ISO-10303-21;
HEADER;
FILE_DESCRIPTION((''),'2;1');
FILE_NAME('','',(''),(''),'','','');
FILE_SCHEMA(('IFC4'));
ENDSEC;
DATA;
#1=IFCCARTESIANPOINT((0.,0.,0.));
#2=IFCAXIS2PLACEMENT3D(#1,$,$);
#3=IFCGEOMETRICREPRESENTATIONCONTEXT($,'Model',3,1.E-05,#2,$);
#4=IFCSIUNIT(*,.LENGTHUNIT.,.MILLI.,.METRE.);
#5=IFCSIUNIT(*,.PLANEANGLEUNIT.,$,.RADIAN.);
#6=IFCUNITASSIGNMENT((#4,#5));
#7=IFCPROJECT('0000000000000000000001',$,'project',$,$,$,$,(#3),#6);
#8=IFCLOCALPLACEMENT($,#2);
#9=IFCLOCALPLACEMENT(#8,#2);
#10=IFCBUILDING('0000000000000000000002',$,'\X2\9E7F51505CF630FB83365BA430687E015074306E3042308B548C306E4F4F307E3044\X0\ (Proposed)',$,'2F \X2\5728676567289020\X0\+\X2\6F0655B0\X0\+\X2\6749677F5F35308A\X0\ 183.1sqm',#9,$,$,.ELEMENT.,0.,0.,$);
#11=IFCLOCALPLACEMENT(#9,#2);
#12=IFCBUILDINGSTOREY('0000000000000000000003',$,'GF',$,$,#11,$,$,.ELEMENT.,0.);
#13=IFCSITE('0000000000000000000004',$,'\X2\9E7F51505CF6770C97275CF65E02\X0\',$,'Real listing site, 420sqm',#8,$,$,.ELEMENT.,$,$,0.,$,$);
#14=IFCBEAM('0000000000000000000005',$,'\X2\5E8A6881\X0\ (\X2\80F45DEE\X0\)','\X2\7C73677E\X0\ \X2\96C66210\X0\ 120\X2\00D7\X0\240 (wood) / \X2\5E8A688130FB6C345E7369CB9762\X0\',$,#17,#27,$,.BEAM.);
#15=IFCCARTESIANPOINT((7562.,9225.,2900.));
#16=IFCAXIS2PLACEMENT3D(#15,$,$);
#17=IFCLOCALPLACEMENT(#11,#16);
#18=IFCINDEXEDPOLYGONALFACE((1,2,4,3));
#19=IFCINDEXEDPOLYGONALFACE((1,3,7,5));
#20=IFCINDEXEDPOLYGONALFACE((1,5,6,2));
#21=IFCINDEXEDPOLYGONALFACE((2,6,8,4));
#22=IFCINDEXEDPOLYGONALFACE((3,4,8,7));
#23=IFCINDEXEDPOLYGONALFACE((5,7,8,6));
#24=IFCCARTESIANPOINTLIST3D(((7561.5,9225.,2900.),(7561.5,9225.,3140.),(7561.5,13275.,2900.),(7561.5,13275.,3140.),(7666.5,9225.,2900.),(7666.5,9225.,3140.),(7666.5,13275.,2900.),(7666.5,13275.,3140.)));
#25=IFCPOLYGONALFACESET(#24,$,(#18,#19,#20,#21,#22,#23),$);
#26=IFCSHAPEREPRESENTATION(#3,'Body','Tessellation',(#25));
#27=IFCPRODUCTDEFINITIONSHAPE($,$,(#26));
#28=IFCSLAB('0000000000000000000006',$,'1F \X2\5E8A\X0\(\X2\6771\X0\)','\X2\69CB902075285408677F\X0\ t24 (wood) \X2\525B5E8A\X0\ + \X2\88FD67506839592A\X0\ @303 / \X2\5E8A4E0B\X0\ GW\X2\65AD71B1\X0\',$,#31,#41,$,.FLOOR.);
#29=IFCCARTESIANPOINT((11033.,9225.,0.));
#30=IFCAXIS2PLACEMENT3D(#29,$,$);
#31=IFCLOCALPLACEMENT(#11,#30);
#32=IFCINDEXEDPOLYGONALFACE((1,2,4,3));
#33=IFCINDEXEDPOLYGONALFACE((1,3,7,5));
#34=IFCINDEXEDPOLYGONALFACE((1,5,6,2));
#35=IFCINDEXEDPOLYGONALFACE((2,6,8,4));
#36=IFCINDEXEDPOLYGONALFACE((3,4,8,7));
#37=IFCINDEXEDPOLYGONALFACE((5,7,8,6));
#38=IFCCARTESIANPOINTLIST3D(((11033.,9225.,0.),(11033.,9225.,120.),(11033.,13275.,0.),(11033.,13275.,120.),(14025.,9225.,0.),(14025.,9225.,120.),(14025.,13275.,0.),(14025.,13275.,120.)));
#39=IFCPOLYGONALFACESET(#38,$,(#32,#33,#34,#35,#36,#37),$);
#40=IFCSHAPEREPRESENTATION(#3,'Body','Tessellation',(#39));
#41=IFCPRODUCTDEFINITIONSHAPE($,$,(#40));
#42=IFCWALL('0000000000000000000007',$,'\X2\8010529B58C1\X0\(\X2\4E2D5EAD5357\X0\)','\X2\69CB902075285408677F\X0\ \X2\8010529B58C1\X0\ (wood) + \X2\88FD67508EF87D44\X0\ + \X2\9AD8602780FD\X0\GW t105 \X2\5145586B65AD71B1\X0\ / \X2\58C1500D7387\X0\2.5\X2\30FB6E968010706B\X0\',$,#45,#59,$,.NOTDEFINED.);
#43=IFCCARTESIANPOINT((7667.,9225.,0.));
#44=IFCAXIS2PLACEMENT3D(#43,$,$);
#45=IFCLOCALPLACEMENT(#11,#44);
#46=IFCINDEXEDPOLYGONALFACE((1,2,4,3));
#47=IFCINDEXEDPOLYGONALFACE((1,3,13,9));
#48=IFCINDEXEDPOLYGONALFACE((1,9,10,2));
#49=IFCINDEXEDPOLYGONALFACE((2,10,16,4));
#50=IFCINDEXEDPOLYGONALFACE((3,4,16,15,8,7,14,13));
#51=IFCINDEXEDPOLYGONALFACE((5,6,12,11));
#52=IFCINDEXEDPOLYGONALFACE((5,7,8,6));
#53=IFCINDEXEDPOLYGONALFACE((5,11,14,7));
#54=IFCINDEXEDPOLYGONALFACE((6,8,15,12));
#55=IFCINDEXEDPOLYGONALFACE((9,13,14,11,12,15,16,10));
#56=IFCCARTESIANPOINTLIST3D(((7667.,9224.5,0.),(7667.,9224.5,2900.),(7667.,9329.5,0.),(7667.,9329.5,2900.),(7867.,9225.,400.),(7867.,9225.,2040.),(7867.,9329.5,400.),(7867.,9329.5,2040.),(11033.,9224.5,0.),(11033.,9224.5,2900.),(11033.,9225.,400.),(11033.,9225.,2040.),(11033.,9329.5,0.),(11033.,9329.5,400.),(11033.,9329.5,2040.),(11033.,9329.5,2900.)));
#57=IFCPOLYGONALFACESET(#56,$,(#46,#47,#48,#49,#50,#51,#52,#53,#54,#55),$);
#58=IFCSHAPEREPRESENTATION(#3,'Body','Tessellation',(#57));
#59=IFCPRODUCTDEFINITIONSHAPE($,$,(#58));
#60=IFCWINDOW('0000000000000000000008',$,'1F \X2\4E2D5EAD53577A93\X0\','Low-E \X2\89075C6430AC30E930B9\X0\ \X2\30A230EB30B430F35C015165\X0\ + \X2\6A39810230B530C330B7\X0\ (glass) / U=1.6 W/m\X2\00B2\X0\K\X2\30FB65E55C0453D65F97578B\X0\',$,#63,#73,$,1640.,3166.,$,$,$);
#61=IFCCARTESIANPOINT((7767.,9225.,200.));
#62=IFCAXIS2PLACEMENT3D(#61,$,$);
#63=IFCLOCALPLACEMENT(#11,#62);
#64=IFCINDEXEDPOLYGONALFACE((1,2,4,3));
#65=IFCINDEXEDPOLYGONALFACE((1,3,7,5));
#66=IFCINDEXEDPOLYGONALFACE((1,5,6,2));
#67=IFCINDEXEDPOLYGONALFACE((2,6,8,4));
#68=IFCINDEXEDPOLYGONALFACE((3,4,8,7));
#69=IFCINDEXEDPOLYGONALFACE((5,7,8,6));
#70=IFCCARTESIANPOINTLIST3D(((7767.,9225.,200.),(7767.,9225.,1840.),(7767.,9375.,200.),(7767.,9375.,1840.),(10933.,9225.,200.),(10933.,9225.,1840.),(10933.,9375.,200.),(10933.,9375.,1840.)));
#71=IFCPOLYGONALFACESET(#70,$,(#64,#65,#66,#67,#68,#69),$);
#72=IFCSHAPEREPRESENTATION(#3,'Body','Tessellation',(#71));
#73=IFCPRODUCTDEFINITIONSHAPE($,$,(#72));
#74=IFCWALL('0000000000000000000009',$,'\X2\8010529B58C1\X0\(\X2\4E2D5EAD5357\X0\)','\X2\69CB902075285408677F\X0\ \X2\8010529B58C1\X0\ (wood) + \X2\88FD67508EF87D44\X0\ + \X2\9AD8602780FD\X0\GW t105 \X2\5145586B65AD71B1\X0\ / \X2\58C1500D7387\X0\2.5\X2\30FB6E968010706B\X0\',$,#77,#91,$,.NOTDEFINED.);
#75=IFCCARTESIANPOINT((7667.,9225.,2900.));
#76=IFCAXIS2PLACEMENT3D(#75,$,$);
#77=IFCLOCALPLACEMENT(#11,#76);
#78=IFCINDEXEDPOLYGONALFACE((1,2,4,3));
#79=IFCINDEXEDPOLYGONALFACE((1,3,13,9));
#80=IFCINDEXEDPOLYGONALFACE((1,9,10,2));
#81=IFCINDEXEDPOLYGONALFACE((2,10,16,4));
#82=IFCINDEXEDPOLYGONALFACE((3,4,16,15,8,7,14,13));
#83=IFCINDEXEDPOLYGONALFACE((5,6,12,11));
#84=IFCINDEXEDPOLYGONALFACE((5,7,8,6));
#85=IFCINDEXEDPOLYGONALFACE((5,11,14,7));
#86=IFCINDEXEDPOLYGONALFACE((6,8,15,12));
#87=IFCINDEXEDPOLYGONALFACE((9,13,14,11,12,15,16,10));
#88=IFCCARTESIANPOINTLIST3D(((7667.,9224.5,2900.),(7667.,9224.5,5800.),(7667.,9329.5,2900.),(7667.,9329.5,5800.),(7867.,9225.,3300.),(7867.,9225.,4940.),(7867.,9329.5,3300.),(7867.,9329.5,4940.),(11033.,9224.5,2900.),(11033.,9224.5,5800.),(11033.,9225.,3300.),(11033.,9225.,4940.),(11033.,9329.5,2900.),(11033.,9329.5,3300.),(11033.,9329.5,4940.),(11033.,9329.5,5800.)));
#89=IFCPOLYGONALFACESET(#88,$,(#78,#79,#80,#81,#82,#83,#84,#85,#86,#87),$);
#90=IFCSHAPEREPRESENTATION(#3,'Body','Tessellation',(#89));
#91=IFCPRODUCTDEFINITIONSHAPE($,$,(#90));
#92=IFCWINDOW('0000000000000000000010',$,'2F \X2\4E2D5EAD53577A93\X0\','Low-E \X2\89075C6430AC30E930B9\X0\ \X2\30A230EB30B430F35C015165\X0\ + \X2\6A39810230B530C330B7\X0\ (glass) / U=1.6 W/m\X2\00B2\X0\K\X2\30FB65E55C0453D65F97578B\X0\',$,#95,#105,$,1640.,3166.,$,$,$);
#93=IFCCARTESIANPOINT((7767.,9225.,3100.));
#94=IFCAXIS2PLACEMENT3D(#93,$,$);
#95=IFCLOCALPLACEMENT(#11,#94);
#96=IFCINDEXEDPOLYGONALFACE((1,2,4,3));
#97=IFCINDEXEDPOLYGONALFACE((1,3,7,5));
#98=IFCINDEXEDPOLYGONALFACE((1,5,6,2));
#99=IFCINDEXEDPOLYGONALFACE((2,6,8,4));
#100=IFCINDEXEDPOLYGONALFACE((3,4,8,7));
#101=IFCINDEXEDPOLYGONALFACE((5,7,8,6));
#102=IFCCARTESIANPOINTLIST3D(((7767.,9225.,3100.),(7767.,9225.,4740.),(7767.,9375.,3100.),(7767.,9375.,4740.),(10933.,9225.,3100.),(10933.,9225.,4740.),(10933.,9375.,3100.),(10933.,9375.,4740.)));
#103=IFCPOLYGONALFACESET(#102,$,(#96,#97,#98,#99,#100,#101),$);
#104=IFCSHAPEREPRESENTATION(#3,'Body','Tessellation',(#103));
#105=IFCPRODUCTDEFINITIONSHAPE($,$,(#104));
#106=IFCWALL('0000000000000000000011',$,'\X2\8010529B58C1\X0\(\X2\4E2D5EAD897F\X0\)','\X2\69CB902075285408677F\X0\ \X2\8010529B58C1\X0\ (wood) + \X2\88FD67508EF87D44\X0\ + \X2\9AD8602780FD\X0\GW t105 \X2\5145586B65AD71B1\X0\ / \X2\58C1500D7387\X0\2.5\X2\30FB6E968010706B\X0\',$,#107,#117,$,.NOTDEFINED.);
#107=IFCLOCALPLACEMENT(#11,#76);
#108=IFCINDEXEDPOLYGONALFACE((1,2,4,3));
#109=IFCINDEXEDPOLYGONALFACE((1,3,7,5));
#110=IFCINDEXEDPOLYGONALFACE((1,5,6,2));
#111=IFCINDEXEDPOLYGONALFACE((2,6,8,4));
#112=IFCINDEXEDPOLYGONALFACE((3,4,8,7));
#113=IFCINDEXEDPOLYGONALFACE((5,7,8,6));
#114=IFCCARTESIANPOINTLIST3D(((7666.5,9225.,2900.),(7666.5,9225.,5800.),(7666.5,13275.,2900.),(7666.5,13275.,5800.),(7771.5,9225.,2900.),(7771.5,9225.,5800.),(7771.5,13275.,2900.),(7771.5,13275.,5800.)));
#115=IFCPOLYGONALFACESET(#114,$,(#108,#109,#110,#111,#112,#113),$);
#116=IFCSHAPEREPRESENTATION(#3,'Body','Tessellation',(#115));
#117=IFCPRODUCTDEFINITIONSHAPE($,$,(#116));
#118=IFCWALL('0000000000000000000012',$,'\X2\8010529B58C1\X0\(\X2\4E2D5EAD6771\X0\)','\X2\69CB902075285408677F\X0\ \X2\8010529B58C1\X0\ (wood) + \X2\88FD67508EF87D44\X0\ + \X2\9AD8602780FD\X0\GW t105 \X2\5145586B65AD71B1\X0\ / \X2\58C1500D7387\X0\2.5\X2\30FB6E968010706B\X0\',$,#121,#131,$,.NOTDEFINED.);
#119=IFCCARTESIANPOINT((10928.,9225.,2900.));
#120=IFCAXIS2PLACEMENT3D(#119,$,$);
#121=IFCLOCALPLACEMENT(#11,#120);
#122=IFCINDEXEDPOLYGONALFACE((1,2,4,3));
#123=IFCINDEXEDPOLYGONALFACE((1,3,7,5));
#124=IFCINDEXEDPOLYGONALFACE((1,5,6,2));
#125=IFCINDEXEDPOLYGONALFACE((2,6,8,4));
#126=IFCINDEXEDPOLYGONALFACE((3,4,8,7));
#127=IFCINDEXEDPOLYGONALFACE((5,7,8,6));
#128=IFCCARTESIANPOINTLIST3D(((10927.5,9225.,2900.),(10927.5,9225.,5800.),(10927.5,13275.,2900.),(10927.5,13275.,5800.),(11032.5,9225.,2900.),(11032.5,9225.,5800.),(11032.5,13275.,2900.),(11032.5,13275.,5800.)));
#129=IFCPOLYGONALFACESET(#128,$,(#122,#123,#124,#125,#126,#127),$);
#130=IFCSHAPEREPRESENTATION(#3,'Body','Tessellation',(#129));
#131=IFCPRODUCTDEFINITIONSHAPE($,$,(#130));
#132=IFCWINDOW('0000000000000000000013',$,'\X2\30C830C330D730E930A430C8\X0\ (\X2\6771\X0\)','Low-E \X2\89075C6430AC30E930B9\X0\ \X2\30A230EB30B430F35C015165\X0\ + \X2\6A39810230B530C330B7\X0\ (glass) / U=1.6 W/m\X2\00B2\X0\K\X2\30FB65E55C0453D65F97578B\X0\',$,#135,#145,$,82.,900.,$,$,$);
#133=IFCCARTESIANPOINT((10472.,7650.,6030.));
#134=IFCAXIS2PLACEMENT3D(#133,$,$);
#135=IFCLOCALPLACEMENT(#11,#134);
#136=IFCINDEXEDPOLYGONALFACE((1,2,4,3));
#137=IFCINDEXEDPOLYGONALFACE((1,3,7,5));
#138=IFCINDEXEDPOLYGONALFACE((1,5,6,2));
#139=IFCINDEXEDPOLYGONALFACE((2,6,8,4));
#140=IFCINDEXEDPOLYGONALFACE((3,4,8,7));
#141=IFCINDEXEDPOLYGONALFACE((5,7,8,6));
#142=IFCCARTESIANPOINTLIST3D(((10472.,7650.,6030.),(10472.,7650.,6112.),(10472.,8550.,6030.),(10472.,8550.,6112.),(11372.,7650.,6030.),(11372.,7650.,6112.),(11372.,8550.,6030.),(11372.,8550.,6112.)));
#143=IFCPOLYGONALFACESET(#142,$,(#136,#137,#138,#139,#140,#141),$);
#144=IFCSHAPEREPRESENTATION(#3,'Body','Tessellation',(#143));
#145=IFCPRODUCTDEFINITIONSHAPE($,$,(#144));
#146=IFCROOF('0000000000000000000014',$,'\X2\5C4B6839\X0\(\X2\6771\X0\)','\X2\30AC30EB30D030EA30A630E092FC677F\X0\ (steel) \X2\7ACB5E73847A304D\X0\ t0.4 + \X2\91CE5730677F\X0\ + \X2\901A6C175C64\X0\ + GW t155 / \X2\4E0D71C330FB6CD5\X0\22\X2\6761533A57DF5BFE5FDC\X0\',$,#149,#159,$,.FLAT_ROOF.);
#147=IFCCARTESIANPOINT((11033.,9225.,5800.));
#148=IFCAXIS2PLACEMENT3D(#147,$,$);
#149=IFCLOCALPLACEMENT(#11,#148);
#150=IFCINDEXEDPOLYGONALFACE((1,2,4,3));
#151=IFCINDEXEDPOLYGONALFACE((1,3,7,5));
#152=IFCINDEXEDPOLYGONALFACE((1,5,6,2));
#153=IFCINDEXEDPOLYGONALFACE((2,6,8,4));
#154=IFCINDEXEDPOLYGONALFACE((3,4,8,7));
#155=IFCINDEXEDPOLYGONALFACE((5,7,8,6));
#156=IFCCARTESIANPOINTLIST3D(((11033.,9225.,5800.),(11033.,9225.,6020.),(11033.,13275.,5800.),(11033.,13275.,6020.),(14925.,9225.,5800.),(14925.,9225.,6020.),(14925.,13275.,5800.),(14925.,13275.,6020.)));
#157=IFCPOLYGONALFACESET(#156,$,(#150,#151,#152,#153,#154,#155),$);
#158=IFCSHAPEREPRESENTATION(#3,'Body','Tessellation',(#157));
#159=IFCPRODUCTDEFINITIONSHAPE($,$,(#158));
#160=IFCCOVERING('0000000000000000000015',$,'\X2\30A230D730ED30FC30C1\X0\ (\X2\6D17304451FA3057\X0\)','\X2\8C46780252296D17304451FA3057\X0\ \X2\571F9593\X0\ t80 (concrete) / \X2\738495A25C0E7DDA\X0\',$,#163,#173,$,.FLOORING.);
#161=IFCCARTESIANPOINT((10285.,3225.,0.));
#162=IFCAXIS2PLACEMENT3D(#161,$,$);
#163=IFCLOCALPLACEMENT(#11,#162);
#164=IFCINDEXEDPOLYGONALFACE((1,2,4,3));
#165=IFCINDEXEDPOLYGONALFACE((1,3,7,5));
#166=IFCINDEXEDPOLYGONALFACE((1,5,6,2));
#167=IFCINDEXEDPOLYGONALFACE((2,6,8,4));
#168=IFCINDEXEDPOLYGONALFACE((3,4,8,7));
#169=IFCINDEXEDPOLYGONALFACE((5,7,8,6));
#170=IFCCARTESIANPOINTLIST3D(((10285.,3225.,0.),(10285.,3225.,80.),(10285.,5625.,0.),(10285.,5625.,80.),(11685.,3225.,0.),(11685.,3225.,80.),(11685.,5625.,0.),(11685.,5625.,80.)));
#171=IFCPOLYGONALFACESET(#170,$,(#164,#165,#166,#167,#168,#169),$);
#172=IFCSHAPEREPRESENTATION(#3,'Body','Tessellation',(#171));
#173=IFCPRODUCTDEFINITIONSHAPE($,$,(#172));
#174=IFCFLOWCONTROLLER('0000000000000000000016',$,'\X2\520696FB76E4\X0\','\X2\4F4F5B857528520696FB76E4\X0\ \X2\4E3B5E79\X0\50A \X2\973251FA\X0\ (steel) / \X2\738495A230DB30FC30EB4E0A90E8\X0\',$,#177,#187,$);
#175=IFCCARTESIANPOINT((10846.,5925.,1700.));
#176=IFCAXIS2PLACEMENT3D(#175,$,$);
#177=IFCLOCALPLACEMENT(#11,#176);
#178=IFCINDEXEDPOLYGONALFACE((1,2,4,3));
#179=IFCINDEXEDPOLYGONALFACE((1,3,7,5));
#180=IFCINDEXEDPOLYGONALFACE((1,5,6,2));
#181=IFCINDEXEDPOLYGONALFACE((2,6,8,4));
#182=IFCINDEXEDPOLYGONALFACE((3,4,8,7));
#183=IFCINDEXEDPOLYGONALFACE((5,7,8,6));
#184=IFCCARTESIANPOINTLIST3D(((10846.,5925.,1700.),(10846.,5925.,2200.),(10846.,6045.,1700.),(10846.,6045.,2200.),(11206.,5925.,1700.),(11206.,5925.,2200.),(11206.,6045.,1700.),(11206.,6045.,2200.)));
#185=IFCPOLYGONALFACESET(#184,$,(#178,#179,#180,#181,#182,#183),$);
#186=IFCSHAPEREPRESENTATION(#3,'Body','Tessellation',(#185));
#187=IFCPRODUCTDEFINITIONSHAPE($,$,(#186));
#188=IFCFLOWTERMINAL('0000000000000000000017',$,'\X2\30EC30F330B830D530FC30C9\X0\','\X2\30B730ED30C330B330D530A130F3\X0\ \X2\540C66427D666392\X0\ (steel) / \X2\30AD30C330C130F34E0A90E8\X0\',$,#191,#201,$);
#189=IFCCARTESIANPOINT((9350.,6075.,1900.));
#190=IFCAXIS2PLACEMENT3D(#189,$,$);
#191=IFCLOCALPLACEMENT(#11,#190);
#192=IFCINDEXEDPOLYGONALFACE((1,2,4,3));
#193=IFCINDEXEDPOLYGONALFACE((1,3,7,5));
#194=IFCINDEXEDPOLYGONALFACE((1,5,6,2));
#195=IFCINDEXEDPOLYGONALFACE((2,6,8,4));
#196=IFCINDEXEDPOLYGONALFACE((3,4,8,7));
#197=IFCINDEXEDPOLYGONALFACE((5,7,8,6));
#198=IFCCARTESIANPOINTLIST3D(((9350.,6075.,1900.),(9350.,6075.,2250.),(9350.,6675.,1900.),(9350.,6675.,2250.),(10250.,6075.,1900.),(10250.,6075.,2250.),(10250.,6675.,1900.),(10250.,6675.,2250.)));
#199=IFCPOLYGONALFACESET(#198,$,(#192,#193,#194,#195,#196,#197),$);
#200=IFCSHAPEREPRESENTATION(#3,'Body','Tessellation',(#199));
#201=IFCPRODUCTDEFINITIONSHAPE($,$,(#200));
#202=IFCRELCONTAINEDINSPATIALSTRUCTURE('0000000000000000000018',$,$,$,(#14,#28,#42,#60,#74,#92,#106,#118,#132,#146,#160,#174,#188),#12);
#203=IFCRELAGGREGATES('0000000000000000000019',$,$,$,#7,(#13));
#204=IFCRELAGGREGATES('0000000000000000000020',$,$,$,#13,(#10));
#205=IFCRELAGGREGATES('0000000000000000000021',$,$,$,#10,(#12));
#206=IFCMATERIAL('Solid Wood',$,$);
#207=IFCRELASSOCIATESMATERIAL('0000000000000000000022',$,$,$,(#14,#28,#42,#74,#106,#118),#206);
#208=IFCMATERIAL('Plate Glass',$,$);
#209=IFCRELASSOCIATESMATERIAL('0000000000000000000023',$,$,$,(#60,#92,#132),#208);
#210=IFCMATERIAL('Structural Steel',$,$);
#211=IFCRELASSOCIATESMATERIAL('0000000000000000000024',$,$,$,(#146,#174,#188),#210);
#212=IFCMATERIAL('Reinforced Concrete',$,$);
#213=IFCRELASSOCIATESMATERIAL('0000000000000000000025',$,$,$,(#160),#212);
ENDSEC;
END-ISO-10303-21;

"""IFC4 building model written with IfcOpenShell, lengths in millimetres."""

from ifc_helpers import new_model, si_unit, frame, frame_2d, origin, place, context, project, spatial, rectangle, extrude, material, element, fill, save


model = new_model("IFC4")

# Units and contexts
model_context = context("Model", 3, precision=1e-05, world=origin())
ifc_project = project(units=[si_unit("LENGTHUNIT", "METRE", prefix="MILLI"), si_unit("PLANEANGLEUNIT", "RADIAN")], contexts=[model_context])

# Site, building, storey
site_placement = place(None, origin())
site = spatial("IfcSite", under=ifc_project, at=site_placement, Name="鹿児島県霧島市", ObjectType="Real listing site, 420sqm", CompositionType="ELEMENT", RefElevation=0.0)
building_placement = place(site_placement, origin())
building = spatial("IfcBuilding", under=site, at=building_placement, Name="鹿児島・茶室と縁側のある和の住まい (Proposed)", ObjectType="2F 在来木造+漆喰+杉板張り 183.1sqm", CompositionType="ELEMENT", ElevationOfRefHeight=0.0, ElevationOfTerrain=0.0)
storey_placement = place(building_placement, origin())
storey = spatial("IfcBuildingStorey", under=building, at=storey_placement, Name="GF", CompositionType="ELEMENT", Elevation=0.0)

# Shared definitions
ifc_material_1 = material(Name="Solid Wood")

# Beam
beam_placement = place(storey_placement, frame((7562.0, 9225.0, 2900.0)))
element("IfcBeam", 1, at=beam_placement, inside=storey, material=ifc_material_1, Name="床梁 (胴差)", Description="米松 集成 120×240 (wood) / 床梁・水平構面", PredefinedType="BEAM", context=model_context, shape_type="SweptSolid", body=[
    extrude(rectangle(XDim=105.0, YDim=4050.0, at=frame_2d((52.0, 2025.0))), frame((7562.0, 9225.0, 2900.0)), (0.0, 0.0, 1.0), 240.0),
])

# Slab
slab_placement = place(storey_placement, frame((11033.0, 9225.0, 0.0)))
element("IfcSlab", 2, at=slab_placement, inside=storey, material=ifc_material_1, Name="1F 床(東)", Description="構造用合板 t24 (wood) 剛床 + 製材根太 @303 / 床下 GW断熱", PredefinedType="FLOOR", context=model_context, shape_type="SweptSolid", body=[
    extrude(rectangle(XDim=2992.0, YDim=4050.0, at=frame_2d((1496.0, 2025.0))), frame((11033.0, 9225.0, 0.0)), (0.0, 0.0, 1.0), 120.0),
])

# Wall, opening, window
wall_1_placement = place(storey_placement, frame((7667.0, 9225.0, 0.0)))
wall_1 = element("IfcWall", 3, at=wall_1_placement, inside=storey, material=ifc_material_1, Name="耐力壁(中庭南)", Description="構造用合板 耐力壁 (wood) + 製材軸組 + 高性能GW t105 充填断熱 / 壁倍率2.5・準耐火", PredefinedType="NOTDEFINED", context=model_context, shape_type="SweptSolid", body=[
    extrude(rectangle(XDim=3366.0, YDim=105.0, at=frame_2d((1683.0, 52.0))), frame((7667.0, 9225.0, 0.0)), (0.0, 0.0, 1.0), 2900.0),
])
opening_1_placement = place(storey_placement, frame((7767.0, 9225.0, 200.0)))
opening_1 = element("IfcOpeningElement", 4, at=opening_1_placement, cuts=wall_1, PredefinedType="NOTDEFINED", context=model_context, shape_type="SweptSolid", body=[
    extrude(rectangle(XDim=3166.0, YDim=150.0, at=frame_2d((1583.0, 75.0))), frame((7767.0, 9225.0, 200.0)), (0.0, 0.0, 1.0), 1640.0),
])
ifc_material_2 = material(Name="Plate Glass")
window_1_placement = place(storey_placement, frame((7767.0, 9225.0, 200.0)))
window_1 = element("IfcWindow", 5, at=window_1_placement, inside=storey, material=ifc_material_2, Name="1F 中庭南窓", Description="Low-E 複層ガラス アルゴン封入 + 樹脂サッシ (glass) / U=1.6 W/m²K・日射取得型", OverallHeight=1640.0, OverallWidth=3166.0, context=model_context, shape_type="SweptSolid", body=[
    extrude(rectangle(XDim=3166.0, YDim=150.0, at=frame_2d((1583.0, 75.0))), frame((7767.0, 9225.0, 200.0)), (0.0, 0.0, 1.0), 1640.0),
])
fill(opening_1, window_1)

# Wall, opening, window
wall_2_placement = place(storey_placement, frame((7667.0, 9225.0, 2900.0)))
wall_2 = element("IfcWall", 6, at=wall_2_placement, inside=storey, material=ifc_material_1, Name="耐力壁(中庭南)", Description="構造用合板 耐力壁 (wood) + 製材軸組 + 高性能GW t105 充填断熱 / 壁倍率2.5・準耐火", PredefinedType="NOTDEFINED", context=model_context, shape_type="SweptSolid", body=[
    extrude(rectangle(XDim=3366.0, YDim=105.0, at=frame_2d((1683.0, 52.0))), frame((7667.0, 9225.0, 2900.0)), (0.0, 0.0, 1.0), 2900.0),
])
opening_2_placement = place(storey_placement, frame((7767.0, 9225.0, 3100.0)))
opening_2 = element("IfcOpeningElement", 7, at=opening_2_placement, cuts=wall_2, PredefinedType="NOTDEFINED", context=model_context, shape_type="SweptSolid", body=[
    extrude(rectangle(XDim=3166.0, YDim=150.0, at=frame_2d((1583.0, 75.0))), frame((7767.0, 9225.0, 3100.0)), (0.0, 0.0, 1.0), 1640.0),
])
window_2_placement = place(storey_placement, frame((7767.0, 9225.0, 3100.0)))
window_2 = element("IfcWindow", 8, at=window_2_placement, inside=storey, material=ifc_material_2, Name="2F 中庭南窓", Description="Low-E 複層ガラス アルゴン封入 + 樹脂サッシ (glass) / U=1.6 W/m²K・日射取得型", OverallHeight=1640.0, OverallWidth=3166.0, context=model_context, shape_type="SweptSolid", body=[
    extrude(rectangle(XDim=3166.0, YDim=150.0, at=frame_2d((1583.0, 75.0))), frame((7767.0, 9225.0, 3100.0)), (0.0, 0.0, 1.0), 1640.0),
])
fill(opening_2, window_2)

# Walls
wall_3_placement = place(storey_placement, frame((7667.0, 9225.0, 2900.0)))
element("IfcWall", 9, at=wall_3_placement, inside=storey, material=ifc_material_1, Name="耐力壁(中庭西)", Description="構造用合板 耐力壁 (wood) + 製材軸組 + 高性能GW t105 充填断熱 / 壁倍率2.5・準耐火", PredefinedType="NOTDEFINED", context=model_context, shape_type="SweptSolid", body=[
    extrude(rectangle(XDim=105.0, YDim=4050.0, at=frame_2d((52.0, 2025.0))), frame((7667.0, 9225.0, 2900.0)), (0.0, 0.0, 1.0), 2900.0),
])
wall_4_placement = place(storey_placement, frame((10928.0, 9225.0, 2900.0)))
element("IfcWall", 10, at=wall_4_placement, inside=storey, material=ifc_material_1, Name="耐力壁(中庭東)", Description="構造用合板 耐力壁 (wood) + 製材軸組 + 高性能GW t105 充填断熱 / 壁倍率2.5・準耐火", PredefinedType="NOTDEFINED", context=model_context, shape_type="SweptSolid", body=[
    extrude(rectangle(XDim=105.0, YDim=4050.0, at=frame_2d((52.0, 2025.0))), frame((10928.0, 9225.0, 2900.0)), (0.0, 0.0, 1.0), 2900.0),
])

# Window
window_3_placement = place(storey_placement, frame((10472.0, 7650.0, 6030.0)))
element("IfcWindow", 11, at=window_3_placement, inside=storey, material=ifc_material_2, Name="トップライト (東)", Description="Low-E 複層ガラス アルゴン封入 + 樹脂サッシ (glass) / U=1.6 W/m²K・日射取得型", OverallHeight=82.0, OverallWidth=900.0, context=model_context, shape_type="SweptSolid", body=[
    extrude(rectangle(XDim=900.0, YDim=900.0, at=frame_2d((450.0, 450.0))), frame((10472.0, 7650.0, 6030.0)), (0.0, 0.0, 1.0), 82.0),
])

# Roof
ifc_material_3 = material(Name="Structural Steel")
roof_placement = place(storey_placement, frame((11033.0, 9225.0, 5800.0)))
element("IfcRoof", 12, at=roof_placement, inside=storey, material=ifc_material_3, Name="屋根(東)", Description="ガルバリウム鋼板 (steel) 立平葺き t0.4 + 野地板 + 通気層 + GW t155 / 不燃・法22条区域対応", PredefinedType="FLAT_ROOF", context=model_context, shape_type="SweptSolid", body=[
    extrude(rectangle(XDim=3892.0, YDim=4050.0, at=frame_2d((1946.0, 2025.0))), frame((11033.0, 9225.0, 5800.0)), (0.0, 0.0, 1.0), 220.0),
])

# Covering
ifc_material_4 = material(Name="Reinforced Concrete")
covering_placement = place(storey_placement, frame((10285.0, 3225.0, 0.0)))
element("IfcCovering", 13, at=covering_placement, inside=storey, material=ifc_material_4, Name="アプローチ (洗い出し)", Description="豆砂利洗い出し 土間 t80 (concrete) / 玄関導線", PredefinedType="FLOORING", context=model_context, shape_type="SweptSolid", body=[
    extrude(rectangle(XDim=1400.0, YDim=2400.0, at=frame_2d((700.0, 1200.0))), frame((10285.0, 3225.0, 0.0)), (0.0, 0.0, 1.0), 80.0),
])

# Flow controller
flow_controller_placement = place(storey_placement, frame((10846.0, 5925.0, 1700.0)))
element("IfcFlowController", 14, at=flow_controller_placement, inside=storey, material=ifc_material_3, Name="分電盤", Description="住宅用分電盤 主幹50A 露出 (steel) / 玄関ホール上部", context=model_context, shape_type="SweptSolid", body=[
    extrude(rectangle(XDim=360.0, YDim=120.0, at=frame_2d((180.0, 60.0))), frame((10846.0, 5925.0, 1700.0)), (0.0, 0.0, 1.0), 500.0),
])

# Flow terminal
flow_terminal_1_placement = place(storey_placement, frame((9350.0, 6075.0, 1900.0)))
element("IfcFlowTerminal", 15, at=flow_terminal_1_placement, inside=storey, material=ifc_material_3, Name="レンジフード", Description="シロッコファン 同時給排 (steel) / キッチン上部", context=model_context, shape_type="SweptSolid", body=[
    extrude(rectangle(XDim=900.0, YDim=600.0, at=frame_2d((450.0, 300.0))), frame((9350.0, 6075.0, 1900.0)), (0.0, 0.0, 1.0), 350.0),
])

save(model, "model.ifc")
